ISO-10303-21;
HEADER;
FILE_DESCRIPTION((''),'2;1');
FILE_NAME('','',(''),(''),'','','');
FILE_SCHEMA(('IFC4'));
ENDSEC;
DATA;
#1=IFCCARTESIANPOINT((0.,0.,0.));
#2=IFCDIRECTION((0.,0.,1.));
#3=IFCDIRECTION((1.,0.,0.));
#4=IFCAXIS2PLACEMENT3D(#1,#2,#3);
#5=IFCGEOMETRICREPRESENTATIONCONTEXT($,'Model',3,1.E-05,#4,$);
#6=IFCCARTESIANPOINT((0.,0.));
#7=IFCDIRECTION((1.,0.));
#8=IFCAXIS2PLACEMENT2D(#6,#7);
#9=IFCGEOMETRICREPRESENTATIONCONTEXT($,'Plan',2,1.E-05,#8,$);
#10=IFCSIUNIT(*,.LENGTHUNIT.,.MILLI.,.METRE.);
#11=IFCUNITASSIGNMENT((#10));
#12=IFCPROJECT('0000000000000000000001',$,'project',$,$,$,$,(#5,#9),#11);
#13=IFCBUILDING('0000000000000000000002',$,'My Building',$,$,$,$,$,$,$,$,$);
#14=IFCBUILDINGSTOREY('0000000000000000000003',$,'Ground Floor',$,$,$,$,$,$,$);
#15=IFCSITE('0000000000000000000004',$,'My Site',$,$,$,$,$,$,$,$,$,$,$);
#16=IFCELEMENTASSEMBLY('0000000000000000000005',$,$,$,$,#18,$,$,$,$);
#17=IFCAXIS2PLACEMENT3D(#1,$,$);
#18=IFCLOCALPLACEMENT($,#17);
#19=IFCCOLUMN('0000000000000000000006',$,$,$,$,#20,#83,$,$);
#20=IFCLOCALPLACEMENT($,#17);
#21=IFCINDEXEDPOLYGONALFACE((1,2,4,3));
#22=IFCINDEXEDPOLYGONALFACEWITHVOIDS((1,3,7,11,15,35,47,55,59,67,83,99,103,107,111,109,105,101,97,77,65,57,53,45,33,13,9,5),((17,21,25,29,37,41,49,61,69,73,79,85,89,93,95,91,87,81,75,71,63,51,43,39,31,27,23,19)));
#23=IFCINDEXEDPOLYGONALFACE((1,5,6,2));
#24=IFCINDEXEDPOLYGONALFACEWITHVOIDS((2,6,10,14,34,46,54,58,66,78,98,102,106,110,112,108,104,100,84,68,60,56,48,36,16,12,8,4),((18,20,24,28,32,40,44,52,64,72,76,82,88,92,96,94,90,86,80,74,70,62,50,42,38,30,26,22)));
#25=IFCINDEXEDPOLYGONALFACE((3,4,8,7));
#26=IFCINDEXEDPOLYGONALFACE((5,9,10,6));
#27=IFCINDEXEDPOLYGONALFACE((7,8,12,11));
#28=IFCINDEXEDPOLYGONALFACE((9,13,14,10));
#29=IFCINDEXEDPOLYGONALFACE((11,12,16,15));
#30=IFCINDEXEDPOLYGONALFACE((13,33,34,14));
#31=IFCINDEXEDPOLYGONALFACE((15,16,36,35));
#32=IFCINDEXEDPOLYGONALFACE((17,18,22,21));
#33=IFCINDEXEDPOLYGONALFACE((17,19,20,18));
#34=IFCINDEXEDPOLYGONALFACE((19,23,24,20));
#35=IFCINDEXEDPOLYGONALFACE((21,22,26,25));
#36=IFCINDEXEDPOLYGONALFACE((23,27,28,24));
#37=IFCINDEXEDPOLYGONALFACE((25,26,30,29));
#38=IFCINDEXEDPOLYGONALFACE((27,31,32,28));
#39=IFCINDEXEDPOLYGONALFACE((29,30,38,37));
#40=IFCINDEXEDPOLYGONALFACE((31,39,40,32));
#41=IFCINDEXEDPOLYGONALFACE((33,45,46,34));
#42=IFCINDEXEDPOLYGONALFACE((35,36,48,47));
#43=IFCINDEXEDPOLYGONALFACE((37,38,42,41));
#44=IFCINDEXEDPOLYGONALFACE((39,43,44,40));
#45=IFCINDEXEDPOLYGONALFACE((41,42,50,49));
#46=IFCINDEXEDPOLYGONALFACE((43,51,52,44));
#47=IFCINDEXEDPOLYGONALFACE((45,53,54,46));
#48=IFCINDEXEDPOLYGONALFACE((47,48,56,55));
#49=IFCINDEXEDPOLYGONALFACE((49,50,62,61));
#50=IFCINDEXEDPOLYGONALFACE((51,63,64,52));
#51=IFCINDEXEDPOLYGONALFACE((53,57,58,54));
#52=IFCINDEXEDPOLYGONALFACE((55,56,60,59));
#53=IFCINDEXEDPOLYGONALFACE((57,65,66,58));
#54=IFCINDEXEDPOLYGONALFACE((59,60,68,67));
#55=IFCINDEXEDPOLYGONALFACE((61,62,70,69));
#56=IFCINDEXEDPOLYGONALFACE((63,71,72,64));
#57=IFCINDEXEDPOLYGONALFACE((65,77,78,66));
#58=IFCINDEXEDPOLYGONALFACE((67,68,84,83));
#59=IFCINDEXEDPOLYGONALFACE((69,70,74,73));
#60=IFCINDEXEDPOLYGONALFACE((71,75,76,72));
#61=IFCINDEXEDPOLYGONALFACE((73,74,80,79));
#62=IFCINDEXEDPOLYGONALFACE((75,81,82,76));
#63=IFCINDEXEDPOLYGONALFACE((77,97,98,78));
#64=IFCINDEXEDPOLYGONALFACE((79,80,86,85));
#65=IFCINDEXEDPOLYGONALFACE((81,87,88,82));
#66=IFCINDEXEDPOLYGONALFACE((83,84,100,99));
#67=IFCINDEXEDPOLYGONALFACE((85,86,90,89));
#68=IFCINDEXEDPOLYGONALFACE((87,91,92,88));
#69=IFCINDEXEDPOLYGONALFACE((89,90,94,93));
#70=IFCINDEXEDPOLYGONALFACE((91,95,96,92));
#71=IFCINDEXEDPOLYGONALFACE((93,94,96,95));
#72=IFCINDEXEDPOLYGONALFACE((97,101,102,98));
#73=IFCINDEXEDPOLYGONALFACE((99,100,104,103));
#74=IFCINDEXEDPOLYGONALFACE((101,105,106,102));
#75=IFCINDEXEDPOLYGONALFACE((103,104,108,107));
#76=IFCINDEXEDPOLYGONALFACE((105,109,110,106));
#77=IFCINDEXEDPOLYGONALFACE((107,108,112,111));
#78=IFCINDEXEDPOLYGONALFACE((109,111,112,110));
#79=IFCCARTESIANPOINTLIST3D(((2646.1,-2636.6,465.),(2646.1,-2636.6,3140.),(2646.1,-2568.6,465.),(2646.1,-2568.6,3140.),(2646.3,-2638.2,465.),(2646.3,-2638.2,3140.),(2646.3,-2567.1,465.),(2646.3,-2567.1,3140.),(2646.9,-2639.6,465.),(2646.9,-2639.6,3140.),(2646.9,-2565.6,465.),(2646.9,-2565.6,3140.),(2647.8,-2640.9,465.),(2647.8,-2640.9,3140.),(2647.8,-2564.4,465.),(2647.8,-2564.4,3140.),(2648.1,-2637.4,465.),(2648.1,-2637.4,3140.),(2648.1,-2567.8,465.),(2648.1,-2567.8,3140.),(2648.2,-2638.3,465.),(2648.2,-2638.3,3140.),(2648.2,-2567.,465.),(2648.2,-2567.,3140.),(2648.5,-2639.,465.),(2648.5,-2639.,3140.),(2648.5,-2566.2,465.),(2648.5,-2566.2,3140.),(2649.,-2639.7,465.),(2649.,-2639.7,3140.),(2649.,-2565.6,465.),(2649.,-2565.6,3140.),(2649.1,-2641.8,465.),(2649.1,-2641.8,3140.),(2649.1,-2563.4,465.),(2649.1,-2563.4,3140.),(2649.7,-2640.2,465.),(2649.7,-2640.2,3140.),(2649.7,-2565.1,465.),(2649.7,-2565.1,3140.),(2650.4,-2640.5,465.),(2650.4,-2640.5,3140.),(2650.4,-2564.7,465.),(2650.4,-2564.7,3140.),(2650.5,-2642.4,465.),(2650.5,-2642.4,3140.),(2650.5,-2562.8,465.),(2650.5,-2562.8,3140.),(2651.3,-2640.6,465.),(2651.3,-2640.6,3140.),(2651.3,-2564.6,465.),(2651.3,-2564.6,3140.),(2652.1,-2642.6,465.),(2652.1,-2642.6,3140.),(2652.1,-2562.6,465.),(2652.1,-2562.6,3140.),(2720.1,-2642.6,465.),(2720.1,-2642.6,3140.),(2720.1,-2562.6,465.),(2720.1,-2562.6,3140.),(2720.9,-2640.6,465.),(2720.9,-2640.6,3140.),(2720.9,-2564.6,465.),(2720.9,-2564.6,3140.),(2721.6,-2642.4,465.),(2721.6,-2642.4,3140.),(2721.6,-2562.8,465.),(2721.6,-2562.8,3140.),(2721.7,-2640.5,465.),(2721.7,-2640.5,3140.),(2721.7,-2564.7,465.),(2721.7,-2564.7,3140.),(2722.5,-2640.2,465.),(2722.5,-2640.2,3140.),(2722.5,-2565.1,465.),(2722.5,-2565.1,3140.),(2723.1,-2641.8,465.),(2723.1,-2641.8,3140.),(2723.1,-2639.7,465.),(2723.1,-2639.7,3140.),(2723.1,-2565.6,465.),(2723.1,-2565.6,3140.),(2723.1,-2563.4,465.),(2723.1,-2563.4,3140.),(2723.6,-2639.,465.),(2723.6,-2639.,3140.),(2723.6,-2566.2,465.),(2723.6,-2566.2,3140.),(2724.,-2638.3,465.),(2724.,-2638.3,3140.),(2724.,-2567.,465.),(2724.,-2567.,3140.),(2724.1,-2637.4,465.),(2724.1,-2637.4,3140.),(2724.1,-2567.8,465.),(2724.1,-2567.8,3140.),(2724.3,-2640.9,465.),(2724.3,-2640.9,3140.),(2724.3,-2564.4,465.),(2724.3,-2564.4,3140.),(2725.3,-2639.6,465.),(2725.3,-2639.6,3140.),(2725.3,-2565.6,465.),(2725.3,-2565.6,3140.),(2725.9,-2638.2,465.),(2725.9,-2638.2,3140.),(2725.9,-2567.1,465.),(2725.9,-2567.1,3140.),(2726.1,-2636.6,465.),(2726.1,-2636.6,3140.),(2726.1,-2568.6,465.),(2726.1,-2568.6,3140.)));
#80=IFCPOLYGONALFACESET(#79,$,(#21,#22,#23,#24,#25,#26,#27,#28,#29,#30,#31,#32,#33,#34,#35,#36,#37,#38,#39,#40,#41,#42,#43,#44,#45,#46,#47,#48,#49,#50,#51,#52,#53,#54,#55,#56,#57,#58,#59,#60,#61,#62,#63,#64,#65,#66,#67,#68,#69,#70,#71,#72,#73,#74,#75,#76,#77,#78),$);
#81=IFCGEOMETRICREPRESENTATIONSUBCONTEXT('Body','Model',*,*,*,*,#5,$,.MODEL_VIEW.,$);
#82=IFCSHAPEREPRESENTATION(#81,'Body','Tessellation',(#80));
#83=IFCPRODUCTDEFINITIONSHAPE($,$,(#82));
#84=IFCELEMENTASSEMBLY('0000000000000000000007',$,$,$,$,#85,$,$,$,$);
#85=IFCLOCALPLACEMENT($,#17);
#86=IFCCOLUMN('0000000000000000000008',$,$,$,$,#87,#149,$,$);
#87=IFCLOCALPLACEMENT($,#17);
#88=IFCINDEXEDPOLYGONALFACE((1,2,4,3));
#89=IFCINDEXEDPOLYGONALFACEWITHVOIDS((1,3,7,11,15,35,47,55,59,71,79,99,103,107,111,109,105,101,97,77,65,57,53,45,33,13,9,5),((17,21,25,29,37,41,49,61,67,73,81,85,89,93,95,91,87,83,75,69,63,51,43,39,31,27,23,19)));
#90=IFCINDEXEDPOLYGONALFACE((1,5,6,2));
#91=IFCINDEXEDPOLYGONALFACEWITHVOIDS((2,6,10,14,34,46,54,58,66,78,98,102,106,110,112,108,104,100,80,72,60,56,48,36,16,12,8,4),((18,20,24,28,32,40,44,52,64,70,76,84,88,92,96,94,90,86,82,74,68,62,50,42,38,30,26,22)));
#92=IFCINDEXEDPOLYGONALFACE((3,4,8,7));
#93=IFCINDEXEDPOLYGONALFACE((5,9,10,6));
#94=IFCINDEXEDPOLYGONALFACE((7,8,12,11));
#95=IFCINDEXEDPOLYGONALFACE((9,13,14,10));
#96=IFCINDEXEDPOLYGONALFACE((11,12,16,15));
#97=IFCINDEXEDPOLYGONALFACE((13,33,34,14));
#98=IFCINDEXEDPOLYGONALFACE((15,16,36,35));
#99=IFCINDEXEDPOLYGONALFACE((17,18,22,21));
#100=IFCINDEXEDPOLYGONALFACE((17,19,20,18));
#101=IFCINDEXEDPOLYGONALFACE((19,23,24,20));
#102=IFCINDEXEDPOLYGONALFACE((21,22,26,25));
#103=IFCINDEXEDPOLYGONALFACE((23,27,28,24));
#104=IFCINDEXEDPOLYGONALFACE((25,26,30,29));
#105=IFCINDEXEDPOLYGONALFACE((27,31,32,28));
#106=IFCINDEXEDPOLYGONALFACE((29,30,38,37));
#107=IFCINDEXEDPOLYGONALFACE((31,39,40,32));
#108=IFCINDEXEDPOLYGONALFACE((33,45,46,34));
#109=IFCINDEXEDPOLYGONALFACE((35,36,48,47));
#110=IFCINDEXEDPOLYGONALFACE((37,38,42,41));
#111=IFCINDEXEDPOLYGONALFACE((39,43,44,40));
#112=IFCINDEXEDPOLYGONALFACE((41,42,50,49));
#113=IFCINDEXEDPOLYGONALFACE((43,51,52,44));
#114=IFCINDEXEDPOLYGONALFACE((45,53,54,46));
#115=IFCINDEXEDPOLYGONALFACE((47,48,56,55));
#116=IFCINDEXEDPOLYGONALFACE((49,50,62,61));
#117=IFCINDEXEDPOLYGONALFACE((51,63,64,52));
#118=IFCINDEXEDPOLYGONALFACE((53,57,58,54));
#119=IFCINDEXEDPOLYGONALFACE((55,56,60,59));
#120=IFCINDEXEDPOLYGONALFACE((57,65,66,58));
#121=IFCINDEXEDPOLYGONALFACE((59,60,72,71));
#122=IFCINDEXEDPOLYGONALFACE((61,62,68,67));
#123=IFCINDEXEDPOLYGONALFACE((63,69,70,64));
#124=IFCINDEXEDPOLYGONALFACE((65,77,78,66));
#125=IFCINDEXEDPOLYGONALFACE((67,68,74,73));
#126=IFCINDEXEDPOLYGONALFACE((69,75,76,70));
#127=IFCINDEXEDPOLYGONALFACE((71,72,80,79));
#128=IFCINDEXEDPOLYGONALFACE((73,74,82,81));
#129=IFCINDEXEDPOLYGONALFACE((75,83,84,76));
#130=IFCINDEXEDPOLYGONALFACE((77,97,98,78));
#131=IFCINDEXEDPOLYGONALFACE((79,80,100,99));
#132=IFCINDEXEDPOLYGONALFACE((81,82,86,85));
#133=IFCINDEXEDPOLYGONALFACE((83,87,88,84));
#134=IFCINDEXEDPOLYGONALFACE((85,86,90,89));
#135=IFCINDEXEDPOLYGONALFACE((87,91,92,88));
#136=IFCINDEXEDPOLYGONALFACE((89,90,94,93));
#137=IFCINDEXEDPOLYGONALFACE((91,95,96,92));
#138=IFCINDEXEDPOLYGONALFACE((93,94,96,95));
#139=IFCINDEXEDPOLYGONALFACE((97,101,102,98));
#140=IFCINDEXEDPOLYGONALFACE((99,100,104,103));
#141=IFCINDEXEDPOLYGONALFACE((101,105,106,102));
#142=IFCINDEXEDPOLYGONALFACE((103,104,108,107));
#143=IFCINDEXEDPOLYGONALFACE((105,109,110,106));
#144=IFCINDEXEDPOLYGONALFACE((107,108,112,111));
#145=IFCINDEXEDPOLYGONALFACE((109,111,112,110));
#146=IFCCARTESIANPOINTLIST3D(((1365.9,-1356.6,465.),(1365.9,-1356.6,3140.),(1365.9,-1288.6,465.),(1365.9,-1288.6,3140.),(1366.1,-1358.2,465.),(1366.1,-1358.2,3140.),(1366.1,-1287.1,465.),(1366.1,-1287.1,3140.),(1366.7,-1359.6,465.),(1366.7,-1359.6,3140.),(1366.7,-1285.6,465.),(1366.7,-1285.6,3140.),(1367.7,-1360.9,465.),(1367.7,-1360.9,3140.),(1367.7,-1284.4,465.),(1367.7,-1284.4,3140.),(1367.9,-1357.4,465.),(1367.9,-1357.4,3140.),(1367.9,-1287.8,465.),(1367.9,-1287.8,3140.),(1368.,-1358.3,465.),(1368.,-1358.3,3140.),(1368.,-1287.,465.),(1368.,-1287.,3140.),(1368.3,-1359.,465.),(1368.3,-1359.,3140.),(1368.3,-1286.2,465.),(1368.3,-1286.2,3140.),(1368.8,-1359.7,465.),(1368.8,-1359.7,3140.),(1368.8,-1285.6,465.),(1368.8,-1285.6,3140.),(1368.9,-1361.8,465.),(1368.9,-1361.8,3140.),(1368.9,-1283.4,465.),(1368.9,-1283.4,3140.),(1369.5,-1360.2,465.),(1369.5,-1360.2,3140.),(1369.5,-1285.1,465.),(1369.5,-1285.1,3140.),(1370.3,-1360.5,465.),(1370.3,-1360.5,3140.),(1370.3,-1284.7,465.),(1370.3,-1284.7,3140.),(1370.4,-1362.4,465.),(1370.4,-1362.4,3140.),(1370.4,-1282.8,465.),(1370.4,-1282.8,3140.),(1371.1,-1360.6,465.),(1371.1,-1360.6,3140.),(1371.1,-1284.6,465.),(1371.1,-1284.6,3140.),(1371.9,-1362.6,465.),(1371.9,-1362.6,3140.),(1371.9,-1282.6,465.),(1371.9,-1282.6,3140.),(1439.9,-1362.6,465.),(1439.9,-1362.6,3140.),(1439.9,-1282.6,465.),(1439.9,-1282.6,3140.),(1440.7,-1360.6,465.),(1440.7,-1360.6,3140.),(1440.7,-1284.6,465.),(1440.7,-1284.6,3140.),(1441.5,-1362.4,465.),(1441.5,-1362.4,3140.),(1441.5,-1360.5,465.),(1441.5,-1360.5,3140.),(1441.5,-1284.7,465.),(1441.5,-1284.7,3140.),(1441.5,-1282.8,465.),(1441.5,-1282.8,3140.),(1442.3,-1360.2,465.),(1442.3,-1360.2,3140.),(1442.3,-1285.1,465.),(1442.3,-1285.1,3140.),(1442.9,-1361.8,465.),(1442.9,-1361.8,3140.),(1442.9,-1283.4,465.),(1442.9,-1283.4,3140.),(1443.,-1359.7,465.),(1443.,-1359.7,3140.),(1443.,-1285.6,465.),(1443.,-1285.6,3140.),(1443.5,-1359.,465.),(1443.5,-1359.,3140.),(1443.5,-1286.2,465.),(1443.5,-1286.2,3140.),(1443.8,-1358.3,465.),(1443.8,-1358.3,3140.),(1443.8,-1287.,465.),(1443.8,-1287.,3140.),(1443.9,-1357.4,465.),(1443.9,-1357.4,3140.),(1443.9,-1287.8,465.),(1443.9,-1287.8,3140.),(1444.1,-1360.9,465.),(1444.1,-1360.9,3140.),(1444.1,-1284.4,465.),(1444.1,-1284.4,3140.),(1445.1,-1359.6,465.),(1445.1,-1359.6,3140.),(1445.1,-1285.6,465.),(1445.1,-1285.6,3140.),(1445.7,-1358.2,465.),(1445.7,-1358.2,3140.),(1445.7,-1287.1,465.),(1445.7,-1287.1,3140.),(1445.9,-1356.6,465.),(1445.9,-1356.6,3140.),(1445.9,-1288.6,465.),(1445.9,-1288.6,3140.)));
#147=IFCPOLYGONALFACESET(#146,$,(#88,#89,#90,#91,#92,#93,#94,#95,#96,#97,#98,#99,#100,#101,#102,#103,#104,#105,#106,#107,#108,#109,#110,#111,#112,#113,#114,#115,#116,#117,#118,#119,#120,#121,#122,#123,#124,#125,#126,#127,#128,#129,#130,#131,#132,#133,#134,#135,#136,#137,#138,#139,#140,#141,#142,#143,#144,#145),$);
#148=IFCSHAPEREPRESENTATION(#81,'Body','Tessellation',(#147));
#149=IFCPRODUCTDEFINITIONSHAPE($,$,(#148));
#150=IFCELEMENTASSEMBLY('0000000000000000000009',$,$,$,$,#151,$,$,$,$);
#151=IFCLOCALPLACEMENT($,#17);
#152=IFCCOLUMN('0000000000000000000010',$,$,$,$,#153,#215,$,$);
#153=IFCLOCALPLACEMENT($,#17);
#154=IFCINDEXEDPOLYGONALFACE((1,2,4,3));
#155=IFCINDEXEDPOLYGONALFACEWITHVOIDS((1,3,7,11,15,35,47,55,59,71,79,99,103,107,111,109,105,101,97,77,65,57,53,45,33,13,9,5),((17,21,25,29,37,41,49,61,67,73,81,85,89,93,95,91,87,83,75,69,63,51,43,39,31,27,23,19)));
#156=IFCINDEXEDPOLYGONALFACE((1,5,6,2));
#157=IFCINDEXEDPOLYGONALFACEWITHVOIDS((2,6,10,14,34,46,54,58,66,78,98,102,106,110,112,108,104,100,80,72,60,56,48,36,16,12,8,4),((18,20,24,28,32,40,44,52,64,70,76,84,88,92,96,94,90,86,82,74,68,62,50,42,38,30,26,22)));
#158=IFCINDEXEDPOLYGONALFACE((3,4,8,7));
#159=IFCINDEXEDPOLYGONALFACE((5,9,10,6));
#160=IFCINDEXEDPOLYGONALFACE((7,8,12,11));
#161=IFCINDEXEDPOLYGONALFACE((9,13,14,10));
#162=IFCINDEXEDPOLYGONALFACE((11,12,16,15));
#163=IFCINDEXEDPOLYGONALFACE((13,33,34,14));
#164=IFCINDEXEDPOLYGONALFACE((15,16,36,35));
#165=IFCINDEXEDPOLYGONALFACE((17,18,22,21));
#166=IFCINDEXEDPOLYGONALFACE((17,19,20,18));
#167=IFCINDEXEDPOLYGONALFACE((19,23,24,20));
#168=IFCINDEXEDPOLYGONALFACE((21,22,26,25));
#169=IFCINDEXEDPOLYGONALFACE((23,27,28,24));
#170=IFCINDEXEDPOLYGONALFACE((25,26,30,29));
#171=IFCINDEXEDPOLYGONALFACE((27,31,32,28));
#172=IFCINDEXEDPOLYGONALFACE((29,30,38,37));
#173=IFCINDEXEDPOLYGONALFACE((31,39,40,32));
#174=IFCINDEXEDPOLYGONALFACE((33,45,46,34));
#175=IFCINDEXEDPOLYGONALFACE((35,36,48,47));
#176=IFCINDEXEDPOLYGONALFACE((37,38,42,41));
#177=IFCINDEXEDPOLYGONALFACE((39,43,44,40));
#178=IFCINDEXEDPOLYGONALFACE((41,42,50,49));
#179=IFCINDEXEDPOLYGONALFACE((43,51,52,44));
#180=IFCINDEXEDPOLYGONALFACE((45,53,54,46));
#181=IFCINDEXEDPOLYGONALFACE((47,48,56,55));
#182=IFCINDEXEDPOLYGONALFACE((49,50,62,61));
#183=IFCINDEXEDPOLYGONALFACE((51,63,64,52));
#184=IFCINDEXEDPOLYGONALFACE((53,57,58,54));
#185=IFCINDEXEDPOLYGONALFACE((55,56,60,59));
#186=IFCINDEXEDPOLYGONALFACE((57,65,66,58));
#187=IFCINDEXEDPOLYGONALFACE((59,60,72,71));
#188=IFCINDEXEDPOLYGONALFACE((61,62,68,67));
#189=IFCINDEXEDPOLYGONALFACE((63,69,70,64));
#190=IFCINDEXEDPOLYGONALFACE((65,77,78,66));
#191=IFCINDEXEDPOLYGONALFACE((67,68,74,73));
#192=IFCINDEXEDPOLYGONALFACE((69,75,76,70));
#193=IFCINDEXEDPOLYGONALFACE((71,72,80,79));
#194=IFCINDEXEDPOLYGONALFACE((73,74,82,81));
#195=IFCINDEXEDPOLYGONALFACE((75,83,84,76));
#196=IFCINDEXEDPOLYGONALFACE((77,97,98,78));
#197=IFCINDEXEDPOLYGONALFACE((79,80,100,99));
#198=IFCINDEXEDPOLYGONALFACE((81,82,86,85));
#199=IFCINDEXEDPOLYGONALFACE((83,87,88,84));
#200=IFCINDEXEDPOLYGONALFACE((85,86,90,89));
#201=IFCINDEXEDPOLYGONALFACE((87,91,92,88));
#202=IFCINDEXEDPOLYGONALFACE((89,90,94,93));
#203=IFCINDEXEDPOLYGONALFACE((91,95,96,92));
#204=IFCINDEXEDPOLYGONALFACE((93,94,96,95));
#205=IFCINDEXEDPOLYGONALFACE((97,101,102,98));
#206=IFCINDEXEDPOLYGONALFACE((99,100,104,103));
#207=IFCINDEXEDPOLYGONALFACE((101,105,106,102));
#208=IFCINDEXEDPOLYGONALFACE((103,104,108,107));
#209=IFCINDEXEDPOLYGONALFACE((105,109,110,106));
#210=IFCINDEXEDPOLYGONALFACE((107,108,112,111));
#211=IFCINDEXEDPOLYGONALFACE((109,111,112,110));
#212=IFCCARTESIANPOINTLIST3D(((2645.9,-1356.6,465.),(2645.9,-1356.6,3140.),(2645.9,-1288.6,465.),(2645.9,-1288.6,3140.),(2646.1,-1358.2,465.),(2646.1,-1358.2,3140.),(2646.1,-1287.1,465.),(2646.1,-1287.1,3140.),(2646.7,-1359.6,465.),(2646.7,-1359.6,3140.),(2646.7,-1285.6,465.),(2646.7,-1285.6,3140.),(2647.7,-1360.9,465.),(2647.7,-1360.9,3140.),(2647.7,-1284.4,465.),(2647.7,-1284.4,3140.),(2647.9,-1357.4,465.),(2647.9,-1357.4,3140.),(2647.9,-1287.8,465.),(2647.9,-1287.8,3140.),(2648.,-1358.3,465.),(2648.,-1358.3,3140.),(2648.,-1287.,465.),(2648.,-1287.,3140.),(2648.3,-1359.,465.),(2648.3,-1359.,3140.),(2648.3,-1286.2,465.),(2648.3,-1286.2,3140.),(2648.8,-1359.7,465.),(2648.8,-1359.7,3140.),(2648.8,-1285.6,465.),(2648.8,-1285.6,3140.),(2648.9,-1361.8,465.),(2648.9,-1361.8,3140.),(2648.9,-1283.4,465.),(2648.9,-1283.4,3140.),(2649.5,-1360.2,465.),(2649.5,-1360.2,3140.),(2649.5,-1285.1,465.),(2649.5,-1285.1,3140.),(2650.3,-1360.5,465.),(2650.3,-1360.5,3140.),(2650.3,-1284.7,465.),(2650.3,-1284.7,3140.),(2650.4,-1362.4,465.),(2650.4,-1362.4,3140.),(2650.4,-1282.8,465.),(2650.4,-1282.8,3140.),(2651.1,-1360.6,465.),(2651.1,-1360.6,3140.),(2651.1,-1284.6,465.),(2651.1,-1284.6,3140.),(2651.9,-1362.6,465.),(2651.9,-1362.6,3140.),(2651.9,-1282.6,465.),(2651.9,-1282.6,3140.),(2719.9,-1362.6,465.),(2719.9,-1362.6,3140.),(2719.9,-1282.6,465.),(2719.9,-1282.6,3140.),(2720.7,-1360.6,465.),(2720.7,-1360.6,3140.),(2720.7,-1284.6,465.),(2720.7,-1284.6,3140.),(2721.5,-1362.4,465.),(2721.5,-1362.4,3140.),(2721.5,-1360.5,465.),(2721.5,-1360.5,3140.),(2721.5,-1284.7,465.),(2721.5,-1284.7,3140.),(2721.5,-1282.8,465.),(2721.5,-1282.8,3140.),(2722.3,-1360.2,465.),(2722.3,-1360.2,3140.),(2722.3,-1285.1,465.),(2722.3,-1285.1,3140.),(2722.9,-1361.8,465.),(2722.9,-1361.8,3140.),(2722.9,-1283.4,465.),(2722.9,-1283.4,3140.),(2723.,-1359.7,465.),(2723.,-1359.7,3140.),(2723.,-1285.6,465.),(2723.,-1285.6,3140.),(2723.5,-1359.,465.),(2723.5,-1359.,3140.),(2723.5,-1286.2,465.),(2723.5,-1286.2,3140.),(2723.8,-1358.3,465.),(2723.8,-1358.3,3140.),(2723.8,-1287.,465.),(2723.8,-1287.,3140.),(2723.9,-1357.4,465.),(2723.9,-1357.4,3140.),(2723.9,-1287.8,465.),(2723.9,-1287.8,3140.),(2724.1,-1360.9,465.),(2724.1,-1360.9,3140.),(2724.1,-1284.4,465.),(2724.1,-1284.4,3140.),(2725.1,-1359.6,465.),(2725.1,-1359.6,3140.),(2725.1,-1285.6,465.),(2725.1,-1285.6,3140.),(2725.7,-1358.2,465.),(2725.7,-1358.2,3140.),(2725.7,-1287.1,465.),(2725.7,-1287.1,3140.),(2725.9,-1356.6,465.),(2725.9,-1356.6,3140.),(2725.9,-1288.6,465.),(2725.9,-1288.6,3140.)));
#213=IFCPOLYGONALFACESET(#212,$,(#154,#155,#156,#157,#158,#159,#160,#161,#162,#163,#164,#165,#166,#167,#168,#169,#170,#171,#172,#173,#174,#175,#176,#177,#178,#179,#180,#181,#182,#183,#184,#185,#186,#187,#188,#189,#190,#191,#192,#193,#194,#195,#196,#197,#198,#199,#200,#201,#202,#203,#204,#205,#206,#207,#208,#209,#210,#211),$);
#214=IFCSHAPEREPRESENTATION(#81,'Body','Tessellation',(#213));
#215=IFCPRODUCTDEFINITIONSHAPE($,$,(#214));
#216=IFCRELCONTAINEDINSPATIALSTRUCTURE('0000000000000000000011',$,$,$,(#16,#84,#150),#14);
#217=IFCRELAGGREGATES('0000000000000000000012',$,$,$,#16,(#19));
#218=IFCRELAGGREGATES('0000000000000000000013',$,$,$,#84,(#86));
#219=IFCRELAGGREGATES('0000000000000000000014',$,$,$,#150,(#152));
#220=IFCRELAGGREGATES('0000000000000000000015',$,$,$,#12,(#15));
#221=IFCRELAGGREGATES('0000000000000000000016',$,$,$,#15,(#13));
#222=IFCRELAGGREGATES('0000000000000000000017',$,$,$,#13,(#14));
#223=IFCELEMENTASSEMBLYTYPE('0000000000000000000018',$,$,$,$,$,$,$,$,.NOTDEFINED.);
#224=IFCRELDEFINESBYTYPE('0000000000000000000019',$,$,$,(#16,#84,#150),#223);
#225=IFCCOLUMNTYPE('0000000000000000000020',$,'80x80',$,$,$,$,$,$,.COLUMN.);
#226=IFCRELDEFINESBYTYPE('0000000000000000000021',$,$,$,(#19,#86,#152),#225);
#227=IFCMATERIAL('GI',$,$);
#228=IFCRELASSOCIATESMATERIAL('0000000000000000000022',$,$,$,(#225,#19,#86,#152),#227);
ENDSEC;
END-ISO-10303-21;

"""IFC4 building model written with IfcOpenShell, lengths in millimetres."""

from ifc_helpers import new_model, si_unit, frame, origin_with_axes, origin_2d_with_axis, place, context, subcontext, project, spatial, hollow_rectangle, extrude, material, material_profile, profile_set, profile_usage, type_object, element, aggregate, save


model = new_model("IFC4")

# Units and contexts
model_context = context("Model", 3, precision=1e-05, world=origin_with_axes())
plan_context = context("Plan", 2, precision=1e-05, world=origin_2d_with_axis())
body_context = subcontext(model_context, "Body", "Model", "MODEL_VIEW")
ifc_project = project(units=[si_unit("LENGTHUNIT", "METRE", prefix="MILLI")], contexts=[model_context, plan_context])

# Site, building, storey
site = spatial("IfcSite", under=ifc_project, Name="My Site")
building = spatial("IfcBuilding", under=site, Name="My Building")
storey = spatial("IfcBuildingStorey", under=building, Name="Ground Floor")

# Element assemblies, columns
element_assembly_type_1 = type_object("IfcElementAssemblyType", PredefinedType="NOTDEFINED")
ifc_material_1 = material(Name="GI")
ifc_material_profile_1 = material_profile(ifc_material_1, hollow_rectangle(XDim=80.0, YDim=80.0, WallThickness=2.0, InnerFilletRadius=3.2, OuterFilletRadius=6.0))
ifc_profile_set_1 = profile_set([ifc_material_profile_1], Name="80x80 GI Rectangular Hollow")
column_type = type_object("IfcColumnType", Name="80x80", PredefinedType="COLUMN", material=ifc_profile_set_1)
assembly_1_placement = place(None, frame((2686.1, -2602.6, 465.0), z_axis=(0.0, 0.0, 1.0), x_axis=(1.0, 0.0, 0.0)))
assembly_1 = element("IfcElementAssembly", 1, at=assembly_1_placement, inside=storey, type_object=element_assembly_type_1)
ifc_profile_usage_1 = profile_usage(ifc_profile_set_1)
column_1_placement = place(assembly_1_placement, origin_with_axes())
column_1 = element("IfcColumn", 2, at=column_1_placement, type_object=column_type, material=ifc_profile_usage_1, context=body_context, shape_type="SweptSolid", body=[
    extrude(hollow_rectangle(XDim=80.0, YDim=80.0, WallThickness=2.0, InnerFilletRadius=3.2, OuterFilletRadius=6.0), origin_with_axes(), (0.0, 0.0, 1.0), 2675.0),
])
aggregate(assembly_1, [column_1])
assembly_2_placement = place(None, frame((1405.9, -1322.6, 465.0), z_axis=(0.0, 0.0, 1.0), x_axis=(1.0, 0.0, 0.0)))
assembly_2 = element("IfcElementAssembly", 3, at=assembly_2_placement, inside=storey, type_object=element_assembly_type_1)
ifc_profile_usage_2 = profile_usage(ifc_profile_set_1)
column_2_placement = place(assembly_2_placement, origin_with_axes())
column_2 = element("IfcColumn", 4, at=column_2_placement, type_object=column_type, material=ifc_profile_usage_2, context=body_context, shape_type="SweptSolid", body=[
    extrude(hollow_rectangle(XDim=80.0, YDim=80.0, WallThickness=2.0, InnerFilletRadius=3.2, OuterFilletRadius=6.0), origin_with_axes(), (0.0, 0.0, 1.0), 2675.0),
])
aggregate(assembly_2, [column_2])
assembly_3_placement = place(None, frame((2685.9, -1322.6, 465.0), z_axis=(0.0, 0.0, 1.0), x_axis=(1.0, 0.0, 0.0)))
assembly_3 = element("IfcElementAssembly", 5, at=assembly_3_placement, inside=storey, type_object=element_assembly_type_1)
ifc_profile_usage_3 = profile_usage(ifc_profile_set_1)
column_3_placement = place(assembly_3_placement, origin_with_axes())
column_3 = element("IfcColumn", 6, at=column_3_placement, type_object=column_type, material=ifc_profile_usage_3, context=body_context, shape_type="SweptSolid", body=[
    extrude(hollow_rectangle(XDim=80.0, YDim=80.0, WallThickness=2.0, InnerFilletRadius=3.2, OuterFilletRadius=6.0), origin_with_axes(), (0.0, 0.0, 1.0), 2675.0),
])
aggregate(assembly_3, [column_3])

save(model, "model.ifc")
